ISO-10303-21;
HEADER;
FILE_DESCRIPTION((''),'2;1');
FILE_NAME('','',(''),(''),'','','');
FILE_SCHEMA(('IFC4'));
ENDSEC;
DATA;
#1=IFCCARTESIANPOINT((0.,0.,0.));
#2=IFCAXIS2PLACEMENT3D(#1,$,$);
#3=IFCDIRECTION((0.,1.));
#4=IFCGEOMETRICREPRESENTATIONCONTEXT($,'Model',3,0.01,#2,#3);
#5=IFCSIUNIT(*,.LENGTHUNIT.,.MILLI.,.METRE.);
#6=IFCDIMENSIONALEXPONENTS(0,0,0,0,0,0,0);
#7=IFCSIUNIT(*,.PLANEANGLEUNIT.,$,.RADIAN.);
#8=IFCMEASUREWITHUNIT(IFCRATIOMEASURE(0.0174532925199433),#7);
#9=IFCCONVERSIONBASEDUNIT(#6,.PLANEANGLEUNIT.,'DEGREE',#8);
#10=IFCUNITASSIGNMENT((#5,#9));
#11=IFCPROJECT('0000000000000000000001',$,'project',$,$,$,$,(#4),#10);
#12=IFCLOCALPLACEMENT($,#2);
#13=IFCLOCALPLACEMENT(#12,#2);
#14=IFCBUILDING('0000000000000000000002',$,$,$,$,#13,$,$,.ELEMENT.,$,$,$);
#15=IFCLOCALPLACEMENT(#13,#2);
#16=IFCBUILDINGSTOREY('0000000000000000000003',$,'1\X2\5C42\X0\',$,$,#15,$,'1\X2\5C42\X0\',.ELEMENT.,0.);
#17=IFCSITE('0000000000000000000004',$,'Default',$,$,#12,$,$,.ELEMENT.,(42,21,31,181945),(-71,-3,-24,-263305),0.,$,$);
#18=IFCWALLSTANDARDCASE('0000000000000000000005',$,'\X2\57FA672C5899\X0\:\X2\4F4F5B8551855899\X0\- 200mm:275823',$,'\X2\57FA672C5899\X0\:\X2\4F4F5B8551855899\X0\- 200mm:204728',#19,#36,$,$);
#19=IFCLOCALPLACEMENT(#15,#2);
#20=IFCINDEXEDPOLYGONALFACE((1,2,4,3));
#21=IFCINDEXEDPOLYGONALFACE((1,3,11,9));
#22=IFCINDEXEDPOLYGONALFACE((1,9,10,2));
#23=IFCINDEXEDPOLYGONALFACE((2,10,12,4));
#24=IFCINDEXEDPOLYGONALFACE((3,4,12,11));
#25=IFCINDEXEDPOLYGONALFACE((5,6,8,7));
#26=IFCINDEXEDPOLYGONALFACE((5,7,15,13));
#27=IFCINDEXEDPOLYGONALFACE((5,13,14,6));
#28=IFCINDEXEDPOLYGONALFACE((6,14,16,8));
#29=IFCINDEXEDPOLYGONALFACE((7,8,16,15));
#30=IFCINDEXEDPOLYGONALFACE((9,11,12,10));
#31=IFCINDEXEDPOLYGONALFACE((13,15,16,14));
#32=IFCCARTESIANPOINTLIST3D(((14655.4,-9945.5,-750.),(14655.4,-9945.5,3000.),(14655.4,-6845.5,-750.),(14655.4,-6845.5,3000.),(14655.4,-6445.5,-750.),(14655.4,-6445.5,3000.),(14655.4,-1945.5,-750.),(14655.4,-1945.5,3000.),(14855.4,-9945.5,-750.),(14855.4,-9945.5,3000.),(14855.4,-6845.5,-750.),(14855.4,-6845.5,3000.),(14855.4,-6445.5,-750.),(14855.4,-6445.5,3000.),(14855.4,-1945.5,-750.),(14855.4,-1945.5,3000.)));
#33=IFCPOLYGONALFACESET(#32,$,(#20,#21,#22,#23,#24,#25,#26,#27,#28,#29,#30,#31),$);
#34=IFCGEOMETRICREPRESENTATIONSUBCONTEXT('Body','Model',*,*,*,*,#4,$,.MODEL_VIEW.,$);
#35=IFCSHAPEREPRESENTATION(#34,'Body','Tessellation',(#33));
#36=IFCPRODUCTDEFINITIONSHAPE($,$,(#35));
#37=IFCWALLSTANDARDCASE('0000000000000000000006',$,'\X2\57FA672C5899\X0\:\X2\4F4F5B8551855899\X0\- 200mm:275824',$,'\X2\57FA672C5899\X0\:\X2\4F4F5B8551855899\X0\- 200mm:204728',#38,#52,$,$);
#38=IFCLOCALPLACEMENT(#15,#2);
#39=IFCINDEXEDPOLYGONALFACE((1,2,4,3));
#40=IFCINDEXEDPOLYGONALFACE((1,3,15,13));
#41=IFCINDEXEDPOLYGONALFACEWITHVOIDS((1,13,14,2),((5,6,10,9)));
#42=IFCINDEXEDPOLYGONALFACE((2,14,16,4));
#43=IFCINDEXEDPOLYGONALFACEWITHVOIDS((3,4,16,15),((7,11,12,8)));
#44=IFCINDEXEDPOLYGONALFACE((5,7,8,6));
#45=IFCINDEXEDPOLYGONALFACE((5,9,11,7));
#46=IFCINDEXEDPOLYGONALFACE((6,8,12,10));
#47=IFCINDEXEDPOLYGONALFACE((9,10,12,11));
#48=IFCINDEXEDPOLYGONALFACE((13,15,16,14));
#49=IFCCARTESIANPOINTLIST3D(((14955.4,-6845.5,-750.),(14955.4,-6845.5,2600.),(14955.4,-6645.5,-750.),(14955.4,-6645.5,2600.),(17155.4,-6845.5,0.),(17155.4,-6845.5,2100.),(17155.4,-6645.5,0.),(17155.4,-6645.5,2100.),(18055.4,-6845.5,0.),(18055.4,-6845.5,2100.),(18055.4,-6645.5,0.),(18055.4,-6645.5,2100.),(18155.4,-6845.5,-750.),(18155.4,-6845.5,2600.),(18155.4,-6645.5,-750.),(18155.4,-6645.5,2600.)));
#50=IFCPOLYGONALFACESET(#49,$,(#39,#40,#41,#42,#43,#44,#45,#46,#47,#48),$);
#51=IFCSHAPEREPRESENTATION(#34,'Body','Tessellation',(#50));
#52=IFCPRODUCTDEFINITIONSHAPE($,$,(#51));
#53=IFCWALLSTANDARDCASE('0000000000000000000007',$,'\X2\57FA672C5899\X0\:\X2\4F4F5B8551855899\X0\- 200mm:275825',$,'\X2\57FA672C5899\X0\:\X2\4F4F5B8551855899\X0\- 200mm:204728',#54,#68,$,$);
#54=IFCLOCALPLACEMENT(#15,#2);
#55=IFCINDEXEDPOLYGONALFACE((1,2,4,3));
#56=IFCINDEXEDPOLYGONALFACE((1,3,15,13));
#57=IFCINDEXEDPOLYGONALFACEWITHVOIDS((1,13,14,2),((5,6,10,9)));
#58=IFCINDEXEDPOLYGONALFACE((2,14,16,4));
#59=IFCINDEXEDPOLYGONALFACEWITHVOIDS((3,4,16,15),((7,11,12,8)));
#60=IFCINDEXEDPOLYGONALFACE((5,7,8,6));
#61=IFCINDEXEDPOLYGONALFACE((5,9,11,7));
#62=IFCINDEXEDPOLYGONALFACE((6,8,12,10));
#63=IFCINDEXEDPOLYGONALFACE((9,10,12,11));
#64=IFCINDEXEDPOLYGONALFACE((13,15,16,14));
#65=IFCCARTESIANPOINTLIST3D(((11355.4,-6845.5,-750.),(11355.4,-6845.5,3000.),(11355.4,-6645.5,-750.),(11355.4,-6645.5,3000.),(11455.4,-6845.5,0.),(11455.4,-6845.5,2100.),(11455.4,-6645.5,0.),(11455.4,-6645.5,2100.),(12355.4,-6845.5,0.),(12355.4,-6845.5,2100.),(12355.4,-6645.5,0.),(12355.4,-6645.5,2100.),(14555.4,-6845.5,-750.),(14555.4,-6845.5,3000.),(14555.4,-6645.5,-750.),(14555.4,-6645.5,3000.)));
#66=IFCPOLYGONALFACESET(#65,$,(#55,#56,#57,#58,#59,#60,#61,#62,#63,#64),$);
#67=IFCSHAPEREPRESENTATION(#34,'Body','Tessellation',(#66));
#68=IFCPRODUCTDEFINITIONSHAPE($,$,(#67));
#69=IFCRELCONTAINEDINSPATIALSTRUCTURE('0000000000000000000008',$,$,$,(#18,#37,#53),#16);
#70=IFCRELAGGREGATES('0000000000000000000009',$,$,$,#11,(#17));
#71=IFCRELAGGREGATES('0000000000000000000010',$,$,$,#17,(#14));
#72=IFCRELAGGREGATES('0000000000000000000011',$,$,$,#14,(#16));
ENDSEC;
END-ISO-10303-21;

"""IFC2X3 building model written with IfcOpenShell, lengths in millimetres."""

from ifc_helpers import new_model, entity, si_unit, converted_unit, direction, frame, frame_2d, origin, place, context, subcontext, project, spatial, polyline, rectangle, extrude, clip, bounded_halfspace, element, save


model = new_model("IFC2X3")

# Units and contexts
model_context = context("Model", 3, precision=0.01, world=origin(), true_north=direction((0.0, 1.0)))
body_context = subcontext(model_context, "Body", "Model", "MODEL_VIEW")
ifc_project = project(units=[si_unit("LENGTHUNIT", "METRE", prefix="MILLI"), converted_unit("PLANEANGLEUNIT", "DEGREE", entity("IfcRatioMeasure", 0.0174532925199433), si_unit("PLANEANGLEUNIT", "RADIAN"), dimensions=[0, 0, 0, 0, 0, 0, 0])], contexts=[model_context])

# Site, building, storey
site_placement = place(None, origin())
site = spatial("IfcSite", under=ifc_project, at=site_placement, Name="Default", CompositionType="ELEMENT", RefLatitude=(42, 21, 31, 181945), RefLongitude=(-71, -3, -24, -263305), RefElevation=0.0)
building_placement = place(site_placement, origin())
building = spatial("IfcBuilding", under=site, at=building_placement, CompositionType="ELEMENT")
storey_placement = place(building_placement, origin())
storey = spatial("IfcBuildingStorey", under=building, at=storey_placement, Name="1层", LongName="1层", CompositionType="ELEMENT", Elevation=0.0)

# Walls, openings
wall_1_placement = place(storey_placement, frame((14755.4, -1945.5, -750.0), z_axis=(0.0, 0.0, 1.0), x_axis=(0.0, -1.0, 0.0)))
wall_1 = element("IfcWallStandardCase", 1, at=wall_1_placement, inside=storey, Name="基本墙:住宅内墙- 200mm:275823", ObjectType="基本墙:住宅内墙- 200mm:204728", context=body_context, shape_type="Clipping", body=[
    clip(extrude(rectangle(XDim=8000.0, YDim=200.0, at=frame_2d((4000.0, 0.0), x_axis=(-1.0, 0.0))), origin(), (0.0, 0.0, 1.0), 3750.0), bounded_halfspace(frame((8000.0, -100.0, 3750.0), z_axis=(1.0, 0.0, 0.0), x_axis=(0.0, 0.0, -1.0)), False, frame((8000.0, -100.0, 3750.0), z_axis=(1.0, 0.0, 0.0), x_axis=(0.0, 0.0, -1.0)), polyline([(0.0, 0.0), (3750.0, 0.0), (3750.0, 200.0), (0.0, 200.0), (0.0, 0.0)]))),
])
opening_1_placement = place(storey_placement, frame((14755.4, -1945.5, -750.0), z_axis=(0.0, 0.0, 1.0), x_axis=(0.0, -1.0, 0.0)))
element("IfcOpeningElement", 2, at=opening_1_placement, cuts=wall_1, ObjectType="Opening", context=body_context, shape_type="SweptSolid", body=[
    extrude(rectangle(XDim=3750.0, YDim=200.0, at=frame_2d((0.0, 0.0), x_axis=(1.0, 0.0))), frame((4900.0, 0.0, 1875.0), z_axis=(-1.0, 0.0, 0.0), x_axis=(0.0, 0.0, 1.0)), (0.0, 0.0, 1.0), 400.0),
])
wall_2_placement = place(storey_placement, frame((18155.4, -6745.5, -750.0), z_axis=(0.0, 0.0, 1.0), x_axis=(-1.0, 0.0, 0.0)))
wall_2 = element("IfcWallStandardCase", 3, at=wall_2_placement, inside=storey, Name="基本墙:住宅内墙- 200mm:275824", ObjectType="基本墙:住宅内墙- 200mm:204728", context=body_context, shape_type="Clipping", body=[
    clip(clip(clip(extrude(rectangle(XDim=3200.0, YDim=200.0, at=frame_2d((1600.0, 0.0), x_axis=(-1.0, 0.0))), origin(), (0.0, 0.0, 1.0), 3350.0), bounded_halfspace(frame((0.0, 100.0, 0.0), z_axis=(-1.0, 0.0, 0.0), x_axis=(0.0, 0.0, -1.0)), False, frame((0.0, 100.0, 0.0), z_axis=(-1.0, 0.0, 0.0), x_axis=(0.0, 0.0, -1.0)), polyline([(0.0, 0.0), (0.0, 200.0), (-3350.0, 200.0), (-3350.0, 0.0), (0.0, 0.0)]))), bounded_halfspace(frame((3200.0, -100.0, 0.0), z_axis=(1.0, 0.0, 0.0), x_axis=(0.0, 0.0, -1.0)), False, frame((3200.0, -100.0, 0.0), z_axis=(1.0, 0.0, 0.0), x_axis=(0.0, 0.0, -1.0)), polyline([(0.0, 0.0), (0.0, 200.0), (-3350.0, 200.0), (-3350.0, 0.0), (0.0, 0.0)]))), bounded_halfspace(frame((0.0, -100.0, 3350.0), z_axis=(0.0, 0.0, 1.0), x_axis=(-1.0, 0.0, 0.0)), False, frame((0.0, -100.0, 3350.0), z_axis=(0.0, 0.0, 1.0), x_axis=(-1.0, 0.0, 0.0)), polyline([(0.0, 0.0), (-3200.0, 0.0), (-3200.0, -200.0), (0.0, -200.0), (0.0, 0.0)]))),
])
opening_2_placement = place(wall_2_placement, frame((100.0, -100.0, 750.0)))
element("IfcOpeningElement", 4, at=opening_2_placement, cuts=wall_2, ObjectType="Opening", context=body_context, shape_type="SweptSolid", body=[
    extrude(rectangle(XDim=2100.0, YDim=900.0, at=frame_2d((1050.0, 450.0), x_axis=(1.0, 0.0))), frame((0.0, 0.0, 0.0), z_axis=(0.0, 1.0, 0.0), x_axis=(0.0, 0.0, 1.0)), (0.0, 0.0, 1.0), 200.0),
])

# Wall, openings
wall_3_placement = place(storey_placement, frame((11355.4, -6745.5, -750.0)))
wall_3 = element("IfcWallStandardCase", 5, at=wall_3_placement, inside=storey, Name="基本墙:住宅内墙- 200mm:275825", ObjectType="基本墙:住宅内墙- 200mm:204728", context=body_context, shape_type="Clipping", body=[
    clip(clip(extrude(rectangle(XDim=3200.0, YDim=200.0, at=frame_2d((1600.0, 0.0), x_axis=(-1.0, 0.0))), origin(), (0.0, 0.0, 1.0), 3750.0), bounded_halfspace(frame((0.0, -100.0, 0.0), z_axis=(1.0, 0.0, 0.0), x_axis=(0.0, 0.0, -1.0)), True, frame((0.0, -100.0, 0.0), z_axis=(1.0, 0.0, 0.0), x_axis=(0.0, 0.0, -1.0)), polyline([(0.0, 0.0), (0.0, 200.0), (-3750.0, 200.0), (-3750.0, 0.0), (0.0, 0.0)]))), bounded_halfspace(frame((3200.0, -100.0, 3750.0), z_axis=(1.0, 0.0, 0.0), x_axis=(0.0, 0.0, -1.0)), False, frame((3200.0, -100.0, 3750.0), z_axis=(1.0, 0.0, 0.0), x_axis=(0.0, 0.0, -1.0)), polyline([(0.0, 0.0), (3750.0, 0.0), (3750.0, 200.0), (0.0, 200.0), (0.0, 0.0)]))),
])
opening_3_placement = place(wall_3_placement, frame((1000.0, 100.0, 750.0)))
element("IfcOpeningElement", 6, at=opening_3_placement, cuts=wall_3, ObjectType="Opening", context=body_context, shape_type="SweptSolid", body=[
    extrude(rectangle(XDim=2100.0, YDim=900.0, at=frame_2d((1050.0, 450.0), x_axis=(1.0, 0.0))), frame((0.0, 0.0, 0.0), z_axis=(0.0, -1.0, 0.0), x_axis=(0.0, 0.0, 1.0)), (0.0, 0.0, 1.0), 200.0),
])
opening_4_placement = place(wall_3_placement, origin())
element("IfcOpeningElement", 7, at=opening_4_placement, cuts=wall_3, ObjectType="Opening", context=body_context, shape_type="SweptSolid", body=[
    extrude(rectangle(XDim=2100.0, YDim=900.0, at=frame_2d((0.0, 0.0), x_axis=(1.0, 0.0))), frame((550.0, -1424.0, 4800.0), z_axis=(0.0, 1.0, 0.0), x_axis=(0.0, 0.0, 1.0)), (0.0, 0.0, 1.0), 3048.0),
])

save(model, "model.ifc")
